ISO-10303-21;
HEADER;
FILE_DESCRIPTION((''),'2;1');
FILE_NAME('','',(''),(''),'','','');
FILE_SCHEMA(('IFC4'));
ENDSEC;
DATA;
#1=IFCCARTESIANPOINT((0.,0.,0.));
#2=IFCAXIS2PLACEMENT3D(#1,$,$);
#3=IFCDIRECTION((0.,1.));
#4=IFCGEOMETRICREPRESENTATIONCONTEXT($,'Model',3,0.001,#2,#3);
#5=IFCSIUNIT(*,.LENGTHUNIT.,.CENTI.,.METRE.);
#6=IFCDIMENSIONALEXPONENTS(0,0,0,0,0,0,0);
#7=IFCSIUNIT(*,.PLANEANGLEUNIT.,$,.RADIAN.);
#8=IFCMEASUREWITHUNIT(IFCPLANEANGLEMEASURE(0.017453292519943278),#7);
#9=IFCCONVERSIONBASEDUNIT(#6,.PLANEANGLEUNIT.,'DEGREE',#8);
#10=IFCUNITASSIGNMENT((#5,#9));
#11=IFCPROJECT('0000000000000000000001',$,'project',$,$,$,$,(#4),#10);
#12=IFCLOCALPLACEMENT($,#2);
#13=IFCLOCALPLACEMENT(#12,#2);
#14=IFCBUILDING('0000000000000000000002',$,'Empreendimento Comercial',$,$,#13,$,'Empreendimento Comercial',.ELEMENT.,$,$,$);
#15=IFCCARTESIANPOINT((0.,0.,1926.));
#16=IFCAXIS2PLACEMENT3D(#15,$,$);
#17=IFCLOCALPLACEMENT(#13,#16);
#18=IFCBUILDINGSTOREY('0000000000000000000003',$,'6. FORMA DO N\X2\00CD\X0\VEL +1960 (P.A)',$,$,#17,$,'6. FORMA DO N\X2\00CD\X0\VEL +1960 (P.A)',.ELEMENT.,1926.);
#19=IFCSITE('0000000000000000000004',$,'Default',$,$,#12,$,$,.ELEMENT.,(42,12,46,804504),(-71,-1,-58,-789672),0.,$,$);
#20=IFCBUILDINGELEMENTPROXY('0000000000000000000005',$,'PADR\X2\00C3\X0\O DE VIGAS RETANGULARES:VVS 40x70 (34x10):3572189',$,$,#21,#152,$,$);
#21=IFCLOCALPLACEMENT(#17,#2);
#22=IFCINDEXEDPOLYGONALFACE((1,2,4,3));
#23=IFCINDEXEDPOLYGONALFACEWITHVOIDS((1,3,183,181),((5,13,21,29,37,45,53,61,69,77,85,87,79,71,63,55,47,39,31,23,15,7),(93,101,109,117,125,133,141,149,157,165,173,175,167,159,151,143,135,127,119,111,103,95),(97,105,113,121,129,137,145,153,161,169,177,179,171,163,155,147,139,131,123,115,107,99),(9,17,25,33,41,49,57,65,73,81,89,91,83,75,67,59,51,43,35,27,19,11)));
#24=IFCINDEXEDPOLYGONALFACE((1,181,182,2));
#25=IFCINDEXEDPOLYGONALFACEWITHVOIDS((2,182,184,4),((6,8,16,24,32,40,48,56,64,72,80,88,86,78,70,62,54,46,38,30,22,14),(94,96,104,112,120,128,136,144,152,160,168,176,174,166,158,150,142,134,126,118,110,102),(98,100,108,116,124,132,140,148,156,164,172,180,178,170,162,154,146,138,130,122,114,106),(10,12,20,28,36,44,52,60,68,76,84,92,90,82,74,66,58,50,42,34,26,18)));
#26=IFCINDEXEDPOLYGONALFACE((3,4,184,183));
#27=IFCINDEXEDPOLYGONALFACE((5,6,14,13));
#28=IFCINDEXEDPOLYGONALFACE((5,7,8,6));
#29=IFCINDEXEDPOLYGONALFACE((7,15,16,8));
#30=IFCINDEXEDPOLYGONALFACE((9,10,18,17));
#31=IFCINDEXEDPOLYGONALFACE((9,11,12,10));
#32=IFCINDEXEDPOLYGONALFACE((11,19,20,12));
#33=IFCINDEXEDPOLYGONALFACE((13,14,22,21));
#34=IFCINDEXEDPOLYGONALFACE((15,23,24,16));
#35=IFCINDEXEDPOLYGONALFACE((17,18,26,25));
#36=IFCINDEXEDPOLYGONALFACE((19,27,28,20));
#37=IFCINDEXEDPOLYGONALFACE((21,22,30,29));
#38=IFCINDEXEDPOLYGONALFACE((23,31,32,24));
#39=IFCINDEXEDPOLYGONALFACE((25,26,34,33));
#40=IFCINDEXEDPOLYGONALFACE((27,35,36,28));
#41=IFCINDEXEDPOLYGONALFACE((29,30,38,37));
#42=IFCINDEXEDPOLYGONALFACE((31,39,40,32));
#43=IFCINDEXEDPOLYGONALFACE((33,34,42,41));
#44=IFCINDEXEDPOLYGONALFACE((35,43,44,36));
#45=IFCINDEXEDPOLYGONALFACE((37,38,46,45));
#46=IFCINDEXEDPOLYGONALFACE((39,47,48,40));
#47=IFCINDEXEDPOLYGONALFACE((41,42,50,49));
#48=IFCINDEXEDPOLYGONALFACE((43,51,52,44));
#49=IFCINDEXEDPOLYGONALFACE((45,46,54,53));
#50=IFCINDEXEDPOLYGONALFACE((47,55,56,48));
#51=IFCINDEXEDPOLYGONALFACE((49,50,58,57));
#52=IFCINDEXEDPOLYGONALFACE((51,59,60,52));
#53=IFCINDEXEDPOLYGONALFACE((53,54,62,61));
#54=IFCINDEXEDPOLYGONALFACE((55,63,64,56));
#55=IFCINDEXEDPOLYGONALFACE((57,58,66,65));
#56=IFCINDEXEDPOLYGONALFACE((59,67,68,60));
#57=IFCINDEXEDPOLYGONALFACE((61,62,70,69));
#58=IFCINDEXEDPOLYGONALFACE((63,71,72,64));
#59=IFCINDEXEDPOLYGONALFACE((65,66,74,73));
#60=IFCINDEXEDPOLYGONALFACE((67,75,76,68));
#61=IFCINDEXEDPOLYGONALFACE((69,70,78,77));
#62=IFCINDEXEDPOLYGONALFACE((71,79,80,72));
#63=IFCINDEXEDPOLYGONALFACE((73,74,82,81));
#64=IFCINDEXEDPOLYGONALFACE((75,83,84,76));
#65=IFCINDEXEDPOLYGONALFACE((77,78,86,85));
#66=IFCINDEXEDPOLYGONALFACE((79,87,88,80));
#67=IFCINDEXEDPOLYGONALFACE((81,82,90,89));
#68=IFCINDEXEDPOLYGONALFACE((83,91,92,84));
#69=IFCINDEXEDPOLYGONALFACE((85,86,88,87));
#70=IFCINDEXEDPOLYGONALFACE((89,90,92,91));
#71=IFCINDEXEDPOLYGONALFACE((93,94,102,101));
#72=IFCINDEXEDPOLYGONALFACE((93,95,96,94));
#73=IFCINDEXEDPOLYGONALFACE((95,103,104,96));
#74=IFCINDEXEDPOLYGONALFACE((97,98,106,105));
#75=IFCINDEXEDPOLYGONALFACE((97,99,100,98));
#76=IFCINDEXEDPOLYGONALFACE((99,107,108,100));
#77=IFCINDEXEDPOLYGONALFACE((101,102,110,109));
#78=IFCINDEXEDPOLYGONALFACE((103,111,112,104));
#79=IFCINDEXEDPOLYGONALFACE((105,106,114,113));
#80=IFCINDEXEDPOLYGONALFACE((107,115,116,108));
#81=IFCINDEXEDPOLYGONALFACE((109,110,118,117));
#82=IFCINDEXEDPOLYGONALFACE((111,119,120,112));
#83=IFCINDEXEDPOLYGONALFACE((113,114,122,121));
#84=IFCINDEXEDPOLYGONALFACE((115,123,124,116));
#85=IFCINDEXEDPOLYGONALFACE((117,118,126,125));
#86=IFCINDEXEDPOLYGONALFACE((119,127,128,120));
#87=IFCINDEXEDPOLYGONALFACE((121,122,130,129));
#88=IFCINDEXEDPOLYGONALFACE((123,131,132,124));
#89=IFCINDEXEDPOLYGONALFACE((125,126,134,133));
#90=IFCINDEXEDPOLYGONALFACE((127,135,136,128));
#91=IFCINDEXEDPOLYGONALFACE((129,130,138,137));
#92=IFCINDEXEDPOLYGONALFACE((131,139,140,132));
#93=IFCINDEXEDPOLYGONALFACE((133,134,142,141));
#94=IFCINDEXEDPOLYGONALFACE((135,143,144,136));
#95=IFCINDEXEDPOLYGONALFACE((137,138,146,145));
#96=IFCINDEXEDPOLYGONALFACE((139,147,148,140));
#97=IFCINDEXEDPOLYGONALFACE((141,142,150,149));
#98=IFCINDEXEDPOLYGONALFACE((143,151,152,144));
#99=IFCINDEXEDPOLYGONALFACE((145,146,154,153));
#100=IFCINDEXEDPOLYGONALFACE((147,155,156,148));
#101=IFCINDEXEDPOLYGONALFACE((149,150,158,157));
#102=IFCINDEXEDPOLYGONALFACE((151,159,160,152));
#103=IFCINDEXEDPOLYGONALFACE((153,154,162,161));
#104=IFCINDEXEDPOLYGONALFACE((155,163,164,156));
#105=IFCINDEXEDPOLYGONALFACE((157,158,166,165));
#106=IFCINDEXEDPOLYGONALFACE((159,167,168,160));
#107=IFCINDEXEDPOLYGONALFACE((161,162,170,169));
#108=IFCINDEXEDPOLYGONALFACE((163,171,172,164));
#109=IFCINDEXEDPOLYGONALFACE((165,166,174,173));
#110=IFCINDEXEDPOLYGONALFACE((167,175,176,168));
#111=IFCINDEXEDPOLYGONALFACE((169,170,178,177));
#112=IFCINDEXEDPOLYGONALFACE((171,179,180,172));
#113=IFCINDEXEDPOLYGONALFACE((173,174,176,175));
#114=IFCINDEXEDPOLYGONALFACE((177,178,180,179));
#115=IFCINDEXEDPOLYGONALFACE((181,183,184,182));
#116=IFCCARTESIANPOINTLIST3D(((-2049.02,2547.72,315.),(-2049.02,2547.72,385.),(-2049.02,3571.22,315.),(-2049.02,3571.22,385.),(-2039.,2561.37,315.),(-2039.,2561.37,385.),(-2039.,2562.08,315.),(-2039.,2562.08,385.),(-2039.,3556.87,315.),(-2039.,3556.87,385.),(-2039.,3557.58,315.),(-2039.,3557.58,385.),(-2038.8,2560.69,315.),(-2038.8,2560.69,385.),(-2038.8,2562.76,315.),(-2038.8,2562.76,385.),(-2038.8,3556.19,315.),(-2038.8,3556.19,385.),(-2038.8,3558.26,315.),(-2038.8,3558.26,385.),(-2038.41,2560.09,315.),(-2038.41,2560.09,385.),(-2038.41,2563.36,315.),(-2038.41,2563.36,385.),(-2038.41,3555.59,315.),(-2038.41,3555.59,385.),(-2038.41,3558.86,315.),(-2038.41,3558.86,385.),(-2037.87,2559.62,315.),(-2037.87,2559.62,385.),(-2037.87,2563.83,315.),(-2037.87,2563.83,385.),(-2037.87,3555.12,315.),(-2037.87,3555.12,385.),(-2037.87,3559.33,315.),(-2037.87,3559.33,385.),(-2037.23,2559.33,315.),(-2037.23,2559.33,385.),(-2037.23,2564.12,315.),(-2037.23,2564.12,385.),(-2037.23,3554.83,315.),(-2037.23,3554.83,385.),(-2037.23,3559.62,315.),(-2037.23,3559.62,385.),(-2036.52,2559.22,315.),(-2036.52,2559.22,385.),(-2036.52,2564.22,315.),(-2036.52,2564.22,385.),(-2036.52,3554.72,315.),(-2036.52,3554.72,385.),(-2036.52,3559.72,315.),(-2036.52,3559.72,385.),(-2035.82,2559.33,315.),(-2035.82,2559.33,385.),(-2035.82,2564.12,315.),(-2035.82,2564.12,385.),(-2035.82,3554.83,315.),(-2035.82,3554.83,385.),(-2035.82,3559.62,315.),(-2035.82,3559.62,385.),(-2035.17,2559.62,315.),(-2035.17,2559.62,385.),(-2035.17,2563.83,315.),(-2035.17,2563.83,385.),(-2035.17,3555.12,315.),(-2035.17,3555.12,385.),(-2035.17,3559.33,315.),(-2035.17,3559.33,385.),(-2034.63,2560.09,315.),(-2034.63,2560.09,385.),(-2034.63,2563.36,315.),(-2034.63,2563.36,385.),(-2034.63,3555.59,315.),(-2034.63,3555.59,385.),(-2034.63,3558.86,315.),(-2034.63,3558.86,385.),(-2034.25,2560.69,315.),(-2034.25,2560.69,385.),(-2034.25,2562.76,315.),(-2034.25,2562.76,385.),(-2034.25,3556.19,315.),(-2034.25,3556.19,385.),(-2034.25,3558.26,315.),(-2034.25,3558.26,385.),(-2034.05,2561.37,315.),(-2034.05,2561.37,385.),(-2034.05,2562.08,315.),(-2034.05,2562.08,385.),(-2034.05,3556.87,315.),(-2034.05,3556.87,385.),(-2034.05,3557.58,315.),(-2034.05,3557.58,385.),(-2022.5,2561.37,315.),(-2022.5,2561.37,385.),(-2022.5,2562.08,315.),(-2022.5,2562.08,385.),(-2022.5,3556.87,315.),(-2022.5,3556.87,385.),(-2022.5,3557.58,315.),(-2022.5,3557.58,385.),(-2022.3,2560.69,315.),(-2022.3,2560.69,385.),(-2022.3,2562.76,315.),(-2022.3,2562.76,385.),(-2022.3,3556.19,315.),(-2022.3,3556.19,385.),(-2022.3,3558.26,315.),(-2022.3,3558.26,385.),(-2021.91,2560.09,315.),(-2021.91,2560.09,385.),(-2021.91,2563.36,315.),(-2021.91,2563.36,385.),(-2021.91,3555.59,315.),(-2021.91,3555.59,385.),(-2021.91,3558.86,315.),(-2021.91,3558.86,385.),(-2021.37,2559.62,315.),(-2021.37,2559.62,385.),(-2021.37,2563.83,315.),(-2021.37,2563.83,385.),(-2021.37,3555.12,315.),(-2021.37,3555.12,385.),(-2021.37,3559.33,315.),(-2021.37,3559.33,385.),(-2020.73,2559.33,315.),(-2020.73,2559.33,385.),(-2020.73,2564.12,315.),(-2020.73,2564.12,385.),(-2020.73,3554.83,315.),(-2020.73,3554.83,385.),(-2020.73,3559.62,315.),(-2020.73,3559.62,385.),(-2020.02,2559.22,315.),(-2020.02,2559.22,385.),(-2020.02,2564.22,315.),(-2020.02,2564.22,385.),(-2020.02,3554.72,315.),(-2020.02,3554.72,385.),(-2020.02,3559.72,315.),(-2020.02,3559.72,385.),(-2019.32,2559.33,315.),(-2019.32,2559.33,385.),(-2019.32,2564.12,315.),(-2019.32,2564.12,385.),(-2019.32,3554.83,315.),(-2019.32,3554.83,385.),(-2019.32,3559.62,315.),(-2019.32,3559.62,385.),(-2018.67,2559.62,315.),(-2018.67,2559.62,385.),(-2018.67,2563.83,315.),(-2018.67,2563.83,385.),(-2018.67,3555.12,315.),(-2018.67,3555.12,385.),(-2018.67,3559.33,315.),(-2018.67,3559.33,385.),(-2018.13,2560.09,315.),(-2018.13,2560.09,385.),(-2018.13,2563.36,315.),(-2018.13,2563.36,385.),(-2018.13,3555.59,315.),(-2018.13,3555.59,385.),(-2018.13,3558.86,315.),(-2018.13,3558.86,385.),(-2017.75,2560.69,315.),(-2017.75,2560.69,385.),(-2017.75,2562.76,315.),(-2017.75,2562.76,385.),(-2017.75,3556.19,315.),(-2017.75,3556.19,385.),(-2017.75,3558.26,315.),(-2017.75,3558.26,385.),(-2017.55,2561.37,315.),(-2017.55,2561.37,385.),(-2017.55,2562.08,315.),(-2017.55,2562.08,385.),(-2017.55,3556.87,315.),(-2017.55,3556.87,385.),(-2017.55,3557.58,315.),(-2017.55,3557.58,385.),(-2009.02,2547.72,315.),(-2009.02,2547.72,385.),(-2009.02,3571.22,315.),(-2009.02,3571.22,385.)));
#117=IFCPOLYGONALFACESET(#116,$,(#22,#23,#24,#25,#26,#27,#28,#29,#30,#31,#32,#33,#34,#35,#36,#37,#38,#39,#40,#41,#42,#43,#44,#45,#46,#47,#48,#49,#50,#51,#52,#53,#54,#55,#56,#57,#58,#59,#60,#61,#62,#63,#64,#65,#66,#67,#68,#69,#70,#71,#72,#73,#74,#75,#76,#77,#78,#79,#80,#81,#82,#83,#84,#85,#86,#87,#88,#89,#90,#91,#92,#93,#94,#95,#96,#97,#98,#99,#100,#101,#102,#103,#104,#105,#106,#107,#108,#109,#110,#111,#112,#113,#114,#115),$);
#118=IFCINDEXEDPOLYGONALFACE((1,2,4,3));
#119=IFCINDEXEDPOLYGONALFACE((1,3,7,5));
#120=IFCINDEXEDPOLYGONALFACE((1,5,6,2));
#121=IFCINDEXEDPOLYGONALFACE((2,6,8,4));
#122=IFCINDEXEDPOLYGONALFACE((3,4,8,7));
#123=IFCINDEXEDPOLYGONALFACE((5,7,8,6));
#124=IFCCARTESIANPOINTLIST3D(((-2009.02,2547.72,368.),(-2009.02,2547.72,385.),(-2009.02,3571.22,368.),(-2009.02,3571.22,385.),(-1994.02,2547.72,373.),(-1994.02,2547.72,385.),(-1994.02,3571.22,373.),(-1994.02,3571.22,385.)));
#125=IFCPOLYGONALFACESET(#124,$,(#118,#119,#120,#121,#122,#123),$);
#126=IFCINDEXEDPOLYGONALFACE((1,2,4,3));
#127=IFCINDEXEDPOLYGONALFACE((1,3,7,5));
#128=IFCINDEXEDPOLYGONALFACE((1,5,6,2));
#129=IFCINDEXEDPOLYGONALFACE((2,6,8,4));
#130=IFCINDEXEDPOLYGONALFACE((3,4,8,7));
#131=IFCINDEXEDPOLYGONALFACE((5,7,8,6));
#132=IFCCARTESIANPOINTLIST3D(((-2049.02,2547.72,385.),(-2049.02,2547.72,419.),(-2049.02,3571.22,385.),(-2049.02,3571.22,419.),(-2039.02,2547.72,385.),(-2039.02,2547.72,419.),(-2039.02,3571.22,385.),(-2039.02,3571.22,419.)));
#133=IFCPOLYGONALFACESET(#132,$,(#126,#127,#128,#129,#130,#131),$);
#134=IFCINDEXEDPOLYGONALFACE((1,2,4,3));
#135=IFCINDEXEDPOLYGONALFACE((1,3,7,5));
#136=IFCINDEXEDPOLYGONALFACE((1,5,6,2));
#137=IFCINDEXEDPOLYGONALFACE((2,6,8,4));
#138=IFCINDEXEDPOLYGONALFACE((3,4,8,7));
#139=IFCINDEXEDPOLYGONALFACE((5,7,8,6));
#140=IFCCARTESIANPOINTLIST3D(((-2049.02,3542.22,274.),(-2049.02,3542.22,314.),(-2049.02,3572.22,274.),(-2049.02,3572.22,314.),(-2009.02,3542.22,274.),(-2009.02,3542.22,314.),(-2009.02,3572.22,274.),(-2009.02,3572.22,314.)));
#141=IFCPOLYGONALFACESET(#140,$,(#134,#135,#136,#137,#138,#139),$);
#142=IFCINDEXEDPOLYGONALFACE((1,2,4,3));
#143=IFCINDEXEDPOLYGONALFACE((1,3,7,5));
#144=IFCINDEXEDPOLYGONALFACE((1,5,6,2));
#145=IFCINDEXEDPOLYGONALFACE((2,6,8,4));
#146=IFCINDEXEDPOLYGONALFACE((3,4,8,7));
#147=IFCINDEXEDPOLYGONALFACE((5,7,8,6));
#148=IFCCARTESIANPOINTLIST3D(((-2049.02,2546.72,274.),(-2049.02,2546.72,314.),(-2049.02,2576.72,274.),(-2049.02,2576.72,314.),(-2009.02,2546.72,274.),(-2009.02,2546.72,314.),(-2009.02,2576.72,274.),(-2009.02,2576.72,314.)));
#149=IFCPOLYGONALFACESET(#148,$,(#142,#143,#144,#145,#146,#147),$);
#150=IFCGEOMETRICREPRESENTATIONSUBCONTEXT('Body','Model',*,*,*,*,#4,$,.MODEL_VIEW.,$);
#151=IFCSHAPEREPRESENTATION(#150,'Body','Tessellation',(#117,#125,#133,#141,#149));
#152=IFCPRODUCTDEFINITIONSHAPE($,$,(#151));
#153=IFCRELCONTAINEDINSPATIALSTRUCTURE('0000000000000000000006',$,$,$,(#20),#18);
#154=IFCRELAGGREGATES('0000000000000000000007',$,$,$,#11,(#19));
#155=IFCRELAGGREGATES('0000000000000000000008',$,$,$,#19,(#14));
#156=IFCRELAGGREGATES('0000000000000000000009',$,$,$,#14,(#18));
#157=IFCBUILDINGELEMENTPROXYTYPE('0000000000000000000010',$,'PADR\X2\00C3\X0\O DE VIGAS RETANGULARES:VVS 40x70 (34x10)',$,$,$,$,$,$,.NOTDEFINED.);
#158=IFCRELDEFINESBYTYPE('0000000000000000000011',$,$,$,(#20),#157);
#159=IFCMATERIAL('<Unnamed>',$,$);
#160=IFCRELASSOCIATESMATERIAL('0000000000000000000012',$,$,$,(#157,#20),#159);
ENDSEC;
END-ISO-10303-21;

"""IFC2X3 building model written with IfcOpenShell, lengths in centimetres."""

from ifc_helpers import new_model, entity, si_unit, converted_unit, direction, frame, frame_2d, origin, origin_2d_with_axis, place, context, subcontext, project, spatial, polyline, circle_curve, parameter, trimmed, segment, composite_curve, rectangle, outline, extrude, source, transform, mapped, material, type_object, type_shapes, element, save


model = new_model("IFC2X3")

# Units and contexts
model_context = context("Model", 3, precision=0.001, world=origin(), true_north=direction((0.0, 1.0)))
body_context = subcontext(model_context, "Body", "Model", "MODEL_VIEW")
ifc_project = project(units=[si_unit("LENGTHUNIT", "METRE", prefix="CENTI"), converted_unit("PLANEANGLEUNIT", "DEGREE", entity("IfcPlaneAngleMeasure", 0.017453292519943278), si_unit("PLANEANGLEUNIT", "RADIAN"), dimensions=[0, 0, 0, 0, 0, 0, 0])], contexts=[model_context])

# Site, building, storey
site_placement = place(None, origin())
site = spatial("IfcSite", under=ifc_project, at=site_placement, Name="Default", CompositionType="ELEMENT", RefLatitude=(42, 12, 46, 804504), RefLongitude=(-71, -1, -58, -789672), RefElevation=0.0)
building_placement = place(site_placement, origin())
building = spatial("IfcBuilding", under=site, at=building_placement, Name="Empreendimento Comercial", LongName="Empreendimento Comercial", CompositionType="ELEMENT")
storey_placement = place(building_placement, frame((0.0, 0.0, 1926.0)))
storey = spatial("IfcBuildingStorey", under=building, at=storey_placement, Name="6. FORMA DO NÍVEL +1960 (P.A)", LongName="6. FORMA DO NÍVEL +1960 (P.A)", CompositionType="ELEMENT", Elevation=1926.0)

# Building element proxy
ifc_material = material(Name="<Unnamed>")
building_element_proxy_type_1 = type_object("IfcBuildingElementProxyType", Name="PADRÃO DE VIGAS RETANGULARES:VVS 40x70 (34x10)", PredefinedType="NOTDEFINED", material=ifc_material)
shared_shape_1 = source(origin(), body_context, "Body", "SweptSolid", [
    extrude(outline(polyline([(-20.0, -511.75), (20.0, -511.75), (20.0, 511.75), (-20.0, 511.75), (-20.0, -511.75)]), holes=[composite_curve([segment(trimmed(circle_curve(frame_2d((9.0, 497.75), x_axis=(0.0, -1.0)), 2.5), [parameter(0.0)], [parameter(180.0)], True, "PARAMETER"), False, "CONTINUOUS"), segment(trimmed(circle_curve(frame_2d((9.0, 497.75), x_axis=(0.0, -1.0)), 2.5), [parameter(180.0)], [parameter(0.0)], True, "PARAMETER"), False, "CONTINUOUS")], self_intersect=False), composite_curve([segment(trimmed(circle_curve(frame_2d((-7.5, 497.75), x_axis=(0.0, -1.0)), 2.5), [parameter(0.0)], [parameter(180.0)], True, "PARAMETER"), False, "CONTINUOUS"), segment(trimmed(circle_curve(frame_2d((-7.5, 497.75), x_axis=(0.0, -1.0)), 2.5), [parameter(180.0)], [parameter(0.0)], True, "PARAMETER"), False, "CONTINUOUS")], self_intersect=False), composite_curve([segment(trimmed(circle_curve(frame_2d((-7.5, -497.75), x_axis=(0.0, -1.0)), 2.5), [parameter(0.0)], [parameter(180.0)], True, "PARAMETER"), False, "CONTINUOUS"), segment(trimmed(circle_curve(frame_2d((-7.5, -497.75), x_axis=(0.0, -1.0)), 2.5), [parameter(180.0)], [parameter(0.0)], True, "PARAMETER"), False, "CONTINUOUS")], self_intersect=False), composite_curve([segment(trimmed(circle_curve(frame_2d((9.0, -497.75), x_axis=(0.0, -1.0)), 2.5), [parameter(0.0)], [parameter(180.0)], True, "PARAMETER"), False, "CONTINUOUS"), segment(trimmed(circle_curve(frame_2d((9.0, -497.75), x_axis=(0.0, -1.0)), 2.5), [parameter(180.0)], [parameter(0.0)], True, "PARAMETER"), False, "CONTINUOUS")], self_intersect=False)]), frame((-2029.02, 3059.47, 2241.0)), (0.0, 0.0, 1.0), 70.0),
    extrude(outline(polyline([(-7.25, -7.5), (4.75, -7.5), (9.75, 7.5), (-7.25, 7.5), (-7.25, -7.5)])), frame((-2001.52, 2547.72, 2303.75), z_axis=(0.0, 1.0, 0.0), x_axis=(0.0, 0.0, -1.0)), (0.0, 0.0, 1.0), 1023.5),
    extrude(rectangle(XDim=10.0, YDim=1023.5, at=frame_2d((0.0, 0.0), x_axis=(1.0, 0.0))), frame((-2044.02, 3059.47, 2311.0)), (0.0, 0.0, 1.0), 34.0),
    extrude(rectangle(XDim=30.0, YDim=40.0, at=frame_2d((0.0, 0.0), x_axis=(1.0, 0.0))), frame((-2029.02, 3557.22, 2200.0), z_axis=(0.0, 0.0, 1.0), x_axis=(0.0, 1.0, 0.0)), (0.0, 0.0, 1.0), 40.0),
    extrude(rectangle(XDim=30.0, YDim=40.0, at=origin_2d_with_axis()), frame((-2029.02, 2561.72, 2200.0), z_axis=(0.0, 0.0, 1.0), x_axis=(0.0, 1.0, 0.0)), (0.0, 0.0, 1.0), 40.0),
])
type_shapes(building_element_proxy_type_1, [shared_shape_1])
proxy_1_placement = place(storey_placement, frame((0.0, 0.0, -1926.0)))
element("IfcBuildingElementProxy", 1, at=proxy_1_placement, inside=storey, type_object=building_element_proxy_type_1, material=ifc_material, Name="PADRÃO DE VIGAS RETANGULARES:VVS 40x70 (34x10):3572189", context=body_context, shape_type="MappedRepresentation", body=[
    mapped(shared_shape_1, transform((0.0, 0.0, 0.0), scale=1.0)),
])

save(model, "model.ifc")
